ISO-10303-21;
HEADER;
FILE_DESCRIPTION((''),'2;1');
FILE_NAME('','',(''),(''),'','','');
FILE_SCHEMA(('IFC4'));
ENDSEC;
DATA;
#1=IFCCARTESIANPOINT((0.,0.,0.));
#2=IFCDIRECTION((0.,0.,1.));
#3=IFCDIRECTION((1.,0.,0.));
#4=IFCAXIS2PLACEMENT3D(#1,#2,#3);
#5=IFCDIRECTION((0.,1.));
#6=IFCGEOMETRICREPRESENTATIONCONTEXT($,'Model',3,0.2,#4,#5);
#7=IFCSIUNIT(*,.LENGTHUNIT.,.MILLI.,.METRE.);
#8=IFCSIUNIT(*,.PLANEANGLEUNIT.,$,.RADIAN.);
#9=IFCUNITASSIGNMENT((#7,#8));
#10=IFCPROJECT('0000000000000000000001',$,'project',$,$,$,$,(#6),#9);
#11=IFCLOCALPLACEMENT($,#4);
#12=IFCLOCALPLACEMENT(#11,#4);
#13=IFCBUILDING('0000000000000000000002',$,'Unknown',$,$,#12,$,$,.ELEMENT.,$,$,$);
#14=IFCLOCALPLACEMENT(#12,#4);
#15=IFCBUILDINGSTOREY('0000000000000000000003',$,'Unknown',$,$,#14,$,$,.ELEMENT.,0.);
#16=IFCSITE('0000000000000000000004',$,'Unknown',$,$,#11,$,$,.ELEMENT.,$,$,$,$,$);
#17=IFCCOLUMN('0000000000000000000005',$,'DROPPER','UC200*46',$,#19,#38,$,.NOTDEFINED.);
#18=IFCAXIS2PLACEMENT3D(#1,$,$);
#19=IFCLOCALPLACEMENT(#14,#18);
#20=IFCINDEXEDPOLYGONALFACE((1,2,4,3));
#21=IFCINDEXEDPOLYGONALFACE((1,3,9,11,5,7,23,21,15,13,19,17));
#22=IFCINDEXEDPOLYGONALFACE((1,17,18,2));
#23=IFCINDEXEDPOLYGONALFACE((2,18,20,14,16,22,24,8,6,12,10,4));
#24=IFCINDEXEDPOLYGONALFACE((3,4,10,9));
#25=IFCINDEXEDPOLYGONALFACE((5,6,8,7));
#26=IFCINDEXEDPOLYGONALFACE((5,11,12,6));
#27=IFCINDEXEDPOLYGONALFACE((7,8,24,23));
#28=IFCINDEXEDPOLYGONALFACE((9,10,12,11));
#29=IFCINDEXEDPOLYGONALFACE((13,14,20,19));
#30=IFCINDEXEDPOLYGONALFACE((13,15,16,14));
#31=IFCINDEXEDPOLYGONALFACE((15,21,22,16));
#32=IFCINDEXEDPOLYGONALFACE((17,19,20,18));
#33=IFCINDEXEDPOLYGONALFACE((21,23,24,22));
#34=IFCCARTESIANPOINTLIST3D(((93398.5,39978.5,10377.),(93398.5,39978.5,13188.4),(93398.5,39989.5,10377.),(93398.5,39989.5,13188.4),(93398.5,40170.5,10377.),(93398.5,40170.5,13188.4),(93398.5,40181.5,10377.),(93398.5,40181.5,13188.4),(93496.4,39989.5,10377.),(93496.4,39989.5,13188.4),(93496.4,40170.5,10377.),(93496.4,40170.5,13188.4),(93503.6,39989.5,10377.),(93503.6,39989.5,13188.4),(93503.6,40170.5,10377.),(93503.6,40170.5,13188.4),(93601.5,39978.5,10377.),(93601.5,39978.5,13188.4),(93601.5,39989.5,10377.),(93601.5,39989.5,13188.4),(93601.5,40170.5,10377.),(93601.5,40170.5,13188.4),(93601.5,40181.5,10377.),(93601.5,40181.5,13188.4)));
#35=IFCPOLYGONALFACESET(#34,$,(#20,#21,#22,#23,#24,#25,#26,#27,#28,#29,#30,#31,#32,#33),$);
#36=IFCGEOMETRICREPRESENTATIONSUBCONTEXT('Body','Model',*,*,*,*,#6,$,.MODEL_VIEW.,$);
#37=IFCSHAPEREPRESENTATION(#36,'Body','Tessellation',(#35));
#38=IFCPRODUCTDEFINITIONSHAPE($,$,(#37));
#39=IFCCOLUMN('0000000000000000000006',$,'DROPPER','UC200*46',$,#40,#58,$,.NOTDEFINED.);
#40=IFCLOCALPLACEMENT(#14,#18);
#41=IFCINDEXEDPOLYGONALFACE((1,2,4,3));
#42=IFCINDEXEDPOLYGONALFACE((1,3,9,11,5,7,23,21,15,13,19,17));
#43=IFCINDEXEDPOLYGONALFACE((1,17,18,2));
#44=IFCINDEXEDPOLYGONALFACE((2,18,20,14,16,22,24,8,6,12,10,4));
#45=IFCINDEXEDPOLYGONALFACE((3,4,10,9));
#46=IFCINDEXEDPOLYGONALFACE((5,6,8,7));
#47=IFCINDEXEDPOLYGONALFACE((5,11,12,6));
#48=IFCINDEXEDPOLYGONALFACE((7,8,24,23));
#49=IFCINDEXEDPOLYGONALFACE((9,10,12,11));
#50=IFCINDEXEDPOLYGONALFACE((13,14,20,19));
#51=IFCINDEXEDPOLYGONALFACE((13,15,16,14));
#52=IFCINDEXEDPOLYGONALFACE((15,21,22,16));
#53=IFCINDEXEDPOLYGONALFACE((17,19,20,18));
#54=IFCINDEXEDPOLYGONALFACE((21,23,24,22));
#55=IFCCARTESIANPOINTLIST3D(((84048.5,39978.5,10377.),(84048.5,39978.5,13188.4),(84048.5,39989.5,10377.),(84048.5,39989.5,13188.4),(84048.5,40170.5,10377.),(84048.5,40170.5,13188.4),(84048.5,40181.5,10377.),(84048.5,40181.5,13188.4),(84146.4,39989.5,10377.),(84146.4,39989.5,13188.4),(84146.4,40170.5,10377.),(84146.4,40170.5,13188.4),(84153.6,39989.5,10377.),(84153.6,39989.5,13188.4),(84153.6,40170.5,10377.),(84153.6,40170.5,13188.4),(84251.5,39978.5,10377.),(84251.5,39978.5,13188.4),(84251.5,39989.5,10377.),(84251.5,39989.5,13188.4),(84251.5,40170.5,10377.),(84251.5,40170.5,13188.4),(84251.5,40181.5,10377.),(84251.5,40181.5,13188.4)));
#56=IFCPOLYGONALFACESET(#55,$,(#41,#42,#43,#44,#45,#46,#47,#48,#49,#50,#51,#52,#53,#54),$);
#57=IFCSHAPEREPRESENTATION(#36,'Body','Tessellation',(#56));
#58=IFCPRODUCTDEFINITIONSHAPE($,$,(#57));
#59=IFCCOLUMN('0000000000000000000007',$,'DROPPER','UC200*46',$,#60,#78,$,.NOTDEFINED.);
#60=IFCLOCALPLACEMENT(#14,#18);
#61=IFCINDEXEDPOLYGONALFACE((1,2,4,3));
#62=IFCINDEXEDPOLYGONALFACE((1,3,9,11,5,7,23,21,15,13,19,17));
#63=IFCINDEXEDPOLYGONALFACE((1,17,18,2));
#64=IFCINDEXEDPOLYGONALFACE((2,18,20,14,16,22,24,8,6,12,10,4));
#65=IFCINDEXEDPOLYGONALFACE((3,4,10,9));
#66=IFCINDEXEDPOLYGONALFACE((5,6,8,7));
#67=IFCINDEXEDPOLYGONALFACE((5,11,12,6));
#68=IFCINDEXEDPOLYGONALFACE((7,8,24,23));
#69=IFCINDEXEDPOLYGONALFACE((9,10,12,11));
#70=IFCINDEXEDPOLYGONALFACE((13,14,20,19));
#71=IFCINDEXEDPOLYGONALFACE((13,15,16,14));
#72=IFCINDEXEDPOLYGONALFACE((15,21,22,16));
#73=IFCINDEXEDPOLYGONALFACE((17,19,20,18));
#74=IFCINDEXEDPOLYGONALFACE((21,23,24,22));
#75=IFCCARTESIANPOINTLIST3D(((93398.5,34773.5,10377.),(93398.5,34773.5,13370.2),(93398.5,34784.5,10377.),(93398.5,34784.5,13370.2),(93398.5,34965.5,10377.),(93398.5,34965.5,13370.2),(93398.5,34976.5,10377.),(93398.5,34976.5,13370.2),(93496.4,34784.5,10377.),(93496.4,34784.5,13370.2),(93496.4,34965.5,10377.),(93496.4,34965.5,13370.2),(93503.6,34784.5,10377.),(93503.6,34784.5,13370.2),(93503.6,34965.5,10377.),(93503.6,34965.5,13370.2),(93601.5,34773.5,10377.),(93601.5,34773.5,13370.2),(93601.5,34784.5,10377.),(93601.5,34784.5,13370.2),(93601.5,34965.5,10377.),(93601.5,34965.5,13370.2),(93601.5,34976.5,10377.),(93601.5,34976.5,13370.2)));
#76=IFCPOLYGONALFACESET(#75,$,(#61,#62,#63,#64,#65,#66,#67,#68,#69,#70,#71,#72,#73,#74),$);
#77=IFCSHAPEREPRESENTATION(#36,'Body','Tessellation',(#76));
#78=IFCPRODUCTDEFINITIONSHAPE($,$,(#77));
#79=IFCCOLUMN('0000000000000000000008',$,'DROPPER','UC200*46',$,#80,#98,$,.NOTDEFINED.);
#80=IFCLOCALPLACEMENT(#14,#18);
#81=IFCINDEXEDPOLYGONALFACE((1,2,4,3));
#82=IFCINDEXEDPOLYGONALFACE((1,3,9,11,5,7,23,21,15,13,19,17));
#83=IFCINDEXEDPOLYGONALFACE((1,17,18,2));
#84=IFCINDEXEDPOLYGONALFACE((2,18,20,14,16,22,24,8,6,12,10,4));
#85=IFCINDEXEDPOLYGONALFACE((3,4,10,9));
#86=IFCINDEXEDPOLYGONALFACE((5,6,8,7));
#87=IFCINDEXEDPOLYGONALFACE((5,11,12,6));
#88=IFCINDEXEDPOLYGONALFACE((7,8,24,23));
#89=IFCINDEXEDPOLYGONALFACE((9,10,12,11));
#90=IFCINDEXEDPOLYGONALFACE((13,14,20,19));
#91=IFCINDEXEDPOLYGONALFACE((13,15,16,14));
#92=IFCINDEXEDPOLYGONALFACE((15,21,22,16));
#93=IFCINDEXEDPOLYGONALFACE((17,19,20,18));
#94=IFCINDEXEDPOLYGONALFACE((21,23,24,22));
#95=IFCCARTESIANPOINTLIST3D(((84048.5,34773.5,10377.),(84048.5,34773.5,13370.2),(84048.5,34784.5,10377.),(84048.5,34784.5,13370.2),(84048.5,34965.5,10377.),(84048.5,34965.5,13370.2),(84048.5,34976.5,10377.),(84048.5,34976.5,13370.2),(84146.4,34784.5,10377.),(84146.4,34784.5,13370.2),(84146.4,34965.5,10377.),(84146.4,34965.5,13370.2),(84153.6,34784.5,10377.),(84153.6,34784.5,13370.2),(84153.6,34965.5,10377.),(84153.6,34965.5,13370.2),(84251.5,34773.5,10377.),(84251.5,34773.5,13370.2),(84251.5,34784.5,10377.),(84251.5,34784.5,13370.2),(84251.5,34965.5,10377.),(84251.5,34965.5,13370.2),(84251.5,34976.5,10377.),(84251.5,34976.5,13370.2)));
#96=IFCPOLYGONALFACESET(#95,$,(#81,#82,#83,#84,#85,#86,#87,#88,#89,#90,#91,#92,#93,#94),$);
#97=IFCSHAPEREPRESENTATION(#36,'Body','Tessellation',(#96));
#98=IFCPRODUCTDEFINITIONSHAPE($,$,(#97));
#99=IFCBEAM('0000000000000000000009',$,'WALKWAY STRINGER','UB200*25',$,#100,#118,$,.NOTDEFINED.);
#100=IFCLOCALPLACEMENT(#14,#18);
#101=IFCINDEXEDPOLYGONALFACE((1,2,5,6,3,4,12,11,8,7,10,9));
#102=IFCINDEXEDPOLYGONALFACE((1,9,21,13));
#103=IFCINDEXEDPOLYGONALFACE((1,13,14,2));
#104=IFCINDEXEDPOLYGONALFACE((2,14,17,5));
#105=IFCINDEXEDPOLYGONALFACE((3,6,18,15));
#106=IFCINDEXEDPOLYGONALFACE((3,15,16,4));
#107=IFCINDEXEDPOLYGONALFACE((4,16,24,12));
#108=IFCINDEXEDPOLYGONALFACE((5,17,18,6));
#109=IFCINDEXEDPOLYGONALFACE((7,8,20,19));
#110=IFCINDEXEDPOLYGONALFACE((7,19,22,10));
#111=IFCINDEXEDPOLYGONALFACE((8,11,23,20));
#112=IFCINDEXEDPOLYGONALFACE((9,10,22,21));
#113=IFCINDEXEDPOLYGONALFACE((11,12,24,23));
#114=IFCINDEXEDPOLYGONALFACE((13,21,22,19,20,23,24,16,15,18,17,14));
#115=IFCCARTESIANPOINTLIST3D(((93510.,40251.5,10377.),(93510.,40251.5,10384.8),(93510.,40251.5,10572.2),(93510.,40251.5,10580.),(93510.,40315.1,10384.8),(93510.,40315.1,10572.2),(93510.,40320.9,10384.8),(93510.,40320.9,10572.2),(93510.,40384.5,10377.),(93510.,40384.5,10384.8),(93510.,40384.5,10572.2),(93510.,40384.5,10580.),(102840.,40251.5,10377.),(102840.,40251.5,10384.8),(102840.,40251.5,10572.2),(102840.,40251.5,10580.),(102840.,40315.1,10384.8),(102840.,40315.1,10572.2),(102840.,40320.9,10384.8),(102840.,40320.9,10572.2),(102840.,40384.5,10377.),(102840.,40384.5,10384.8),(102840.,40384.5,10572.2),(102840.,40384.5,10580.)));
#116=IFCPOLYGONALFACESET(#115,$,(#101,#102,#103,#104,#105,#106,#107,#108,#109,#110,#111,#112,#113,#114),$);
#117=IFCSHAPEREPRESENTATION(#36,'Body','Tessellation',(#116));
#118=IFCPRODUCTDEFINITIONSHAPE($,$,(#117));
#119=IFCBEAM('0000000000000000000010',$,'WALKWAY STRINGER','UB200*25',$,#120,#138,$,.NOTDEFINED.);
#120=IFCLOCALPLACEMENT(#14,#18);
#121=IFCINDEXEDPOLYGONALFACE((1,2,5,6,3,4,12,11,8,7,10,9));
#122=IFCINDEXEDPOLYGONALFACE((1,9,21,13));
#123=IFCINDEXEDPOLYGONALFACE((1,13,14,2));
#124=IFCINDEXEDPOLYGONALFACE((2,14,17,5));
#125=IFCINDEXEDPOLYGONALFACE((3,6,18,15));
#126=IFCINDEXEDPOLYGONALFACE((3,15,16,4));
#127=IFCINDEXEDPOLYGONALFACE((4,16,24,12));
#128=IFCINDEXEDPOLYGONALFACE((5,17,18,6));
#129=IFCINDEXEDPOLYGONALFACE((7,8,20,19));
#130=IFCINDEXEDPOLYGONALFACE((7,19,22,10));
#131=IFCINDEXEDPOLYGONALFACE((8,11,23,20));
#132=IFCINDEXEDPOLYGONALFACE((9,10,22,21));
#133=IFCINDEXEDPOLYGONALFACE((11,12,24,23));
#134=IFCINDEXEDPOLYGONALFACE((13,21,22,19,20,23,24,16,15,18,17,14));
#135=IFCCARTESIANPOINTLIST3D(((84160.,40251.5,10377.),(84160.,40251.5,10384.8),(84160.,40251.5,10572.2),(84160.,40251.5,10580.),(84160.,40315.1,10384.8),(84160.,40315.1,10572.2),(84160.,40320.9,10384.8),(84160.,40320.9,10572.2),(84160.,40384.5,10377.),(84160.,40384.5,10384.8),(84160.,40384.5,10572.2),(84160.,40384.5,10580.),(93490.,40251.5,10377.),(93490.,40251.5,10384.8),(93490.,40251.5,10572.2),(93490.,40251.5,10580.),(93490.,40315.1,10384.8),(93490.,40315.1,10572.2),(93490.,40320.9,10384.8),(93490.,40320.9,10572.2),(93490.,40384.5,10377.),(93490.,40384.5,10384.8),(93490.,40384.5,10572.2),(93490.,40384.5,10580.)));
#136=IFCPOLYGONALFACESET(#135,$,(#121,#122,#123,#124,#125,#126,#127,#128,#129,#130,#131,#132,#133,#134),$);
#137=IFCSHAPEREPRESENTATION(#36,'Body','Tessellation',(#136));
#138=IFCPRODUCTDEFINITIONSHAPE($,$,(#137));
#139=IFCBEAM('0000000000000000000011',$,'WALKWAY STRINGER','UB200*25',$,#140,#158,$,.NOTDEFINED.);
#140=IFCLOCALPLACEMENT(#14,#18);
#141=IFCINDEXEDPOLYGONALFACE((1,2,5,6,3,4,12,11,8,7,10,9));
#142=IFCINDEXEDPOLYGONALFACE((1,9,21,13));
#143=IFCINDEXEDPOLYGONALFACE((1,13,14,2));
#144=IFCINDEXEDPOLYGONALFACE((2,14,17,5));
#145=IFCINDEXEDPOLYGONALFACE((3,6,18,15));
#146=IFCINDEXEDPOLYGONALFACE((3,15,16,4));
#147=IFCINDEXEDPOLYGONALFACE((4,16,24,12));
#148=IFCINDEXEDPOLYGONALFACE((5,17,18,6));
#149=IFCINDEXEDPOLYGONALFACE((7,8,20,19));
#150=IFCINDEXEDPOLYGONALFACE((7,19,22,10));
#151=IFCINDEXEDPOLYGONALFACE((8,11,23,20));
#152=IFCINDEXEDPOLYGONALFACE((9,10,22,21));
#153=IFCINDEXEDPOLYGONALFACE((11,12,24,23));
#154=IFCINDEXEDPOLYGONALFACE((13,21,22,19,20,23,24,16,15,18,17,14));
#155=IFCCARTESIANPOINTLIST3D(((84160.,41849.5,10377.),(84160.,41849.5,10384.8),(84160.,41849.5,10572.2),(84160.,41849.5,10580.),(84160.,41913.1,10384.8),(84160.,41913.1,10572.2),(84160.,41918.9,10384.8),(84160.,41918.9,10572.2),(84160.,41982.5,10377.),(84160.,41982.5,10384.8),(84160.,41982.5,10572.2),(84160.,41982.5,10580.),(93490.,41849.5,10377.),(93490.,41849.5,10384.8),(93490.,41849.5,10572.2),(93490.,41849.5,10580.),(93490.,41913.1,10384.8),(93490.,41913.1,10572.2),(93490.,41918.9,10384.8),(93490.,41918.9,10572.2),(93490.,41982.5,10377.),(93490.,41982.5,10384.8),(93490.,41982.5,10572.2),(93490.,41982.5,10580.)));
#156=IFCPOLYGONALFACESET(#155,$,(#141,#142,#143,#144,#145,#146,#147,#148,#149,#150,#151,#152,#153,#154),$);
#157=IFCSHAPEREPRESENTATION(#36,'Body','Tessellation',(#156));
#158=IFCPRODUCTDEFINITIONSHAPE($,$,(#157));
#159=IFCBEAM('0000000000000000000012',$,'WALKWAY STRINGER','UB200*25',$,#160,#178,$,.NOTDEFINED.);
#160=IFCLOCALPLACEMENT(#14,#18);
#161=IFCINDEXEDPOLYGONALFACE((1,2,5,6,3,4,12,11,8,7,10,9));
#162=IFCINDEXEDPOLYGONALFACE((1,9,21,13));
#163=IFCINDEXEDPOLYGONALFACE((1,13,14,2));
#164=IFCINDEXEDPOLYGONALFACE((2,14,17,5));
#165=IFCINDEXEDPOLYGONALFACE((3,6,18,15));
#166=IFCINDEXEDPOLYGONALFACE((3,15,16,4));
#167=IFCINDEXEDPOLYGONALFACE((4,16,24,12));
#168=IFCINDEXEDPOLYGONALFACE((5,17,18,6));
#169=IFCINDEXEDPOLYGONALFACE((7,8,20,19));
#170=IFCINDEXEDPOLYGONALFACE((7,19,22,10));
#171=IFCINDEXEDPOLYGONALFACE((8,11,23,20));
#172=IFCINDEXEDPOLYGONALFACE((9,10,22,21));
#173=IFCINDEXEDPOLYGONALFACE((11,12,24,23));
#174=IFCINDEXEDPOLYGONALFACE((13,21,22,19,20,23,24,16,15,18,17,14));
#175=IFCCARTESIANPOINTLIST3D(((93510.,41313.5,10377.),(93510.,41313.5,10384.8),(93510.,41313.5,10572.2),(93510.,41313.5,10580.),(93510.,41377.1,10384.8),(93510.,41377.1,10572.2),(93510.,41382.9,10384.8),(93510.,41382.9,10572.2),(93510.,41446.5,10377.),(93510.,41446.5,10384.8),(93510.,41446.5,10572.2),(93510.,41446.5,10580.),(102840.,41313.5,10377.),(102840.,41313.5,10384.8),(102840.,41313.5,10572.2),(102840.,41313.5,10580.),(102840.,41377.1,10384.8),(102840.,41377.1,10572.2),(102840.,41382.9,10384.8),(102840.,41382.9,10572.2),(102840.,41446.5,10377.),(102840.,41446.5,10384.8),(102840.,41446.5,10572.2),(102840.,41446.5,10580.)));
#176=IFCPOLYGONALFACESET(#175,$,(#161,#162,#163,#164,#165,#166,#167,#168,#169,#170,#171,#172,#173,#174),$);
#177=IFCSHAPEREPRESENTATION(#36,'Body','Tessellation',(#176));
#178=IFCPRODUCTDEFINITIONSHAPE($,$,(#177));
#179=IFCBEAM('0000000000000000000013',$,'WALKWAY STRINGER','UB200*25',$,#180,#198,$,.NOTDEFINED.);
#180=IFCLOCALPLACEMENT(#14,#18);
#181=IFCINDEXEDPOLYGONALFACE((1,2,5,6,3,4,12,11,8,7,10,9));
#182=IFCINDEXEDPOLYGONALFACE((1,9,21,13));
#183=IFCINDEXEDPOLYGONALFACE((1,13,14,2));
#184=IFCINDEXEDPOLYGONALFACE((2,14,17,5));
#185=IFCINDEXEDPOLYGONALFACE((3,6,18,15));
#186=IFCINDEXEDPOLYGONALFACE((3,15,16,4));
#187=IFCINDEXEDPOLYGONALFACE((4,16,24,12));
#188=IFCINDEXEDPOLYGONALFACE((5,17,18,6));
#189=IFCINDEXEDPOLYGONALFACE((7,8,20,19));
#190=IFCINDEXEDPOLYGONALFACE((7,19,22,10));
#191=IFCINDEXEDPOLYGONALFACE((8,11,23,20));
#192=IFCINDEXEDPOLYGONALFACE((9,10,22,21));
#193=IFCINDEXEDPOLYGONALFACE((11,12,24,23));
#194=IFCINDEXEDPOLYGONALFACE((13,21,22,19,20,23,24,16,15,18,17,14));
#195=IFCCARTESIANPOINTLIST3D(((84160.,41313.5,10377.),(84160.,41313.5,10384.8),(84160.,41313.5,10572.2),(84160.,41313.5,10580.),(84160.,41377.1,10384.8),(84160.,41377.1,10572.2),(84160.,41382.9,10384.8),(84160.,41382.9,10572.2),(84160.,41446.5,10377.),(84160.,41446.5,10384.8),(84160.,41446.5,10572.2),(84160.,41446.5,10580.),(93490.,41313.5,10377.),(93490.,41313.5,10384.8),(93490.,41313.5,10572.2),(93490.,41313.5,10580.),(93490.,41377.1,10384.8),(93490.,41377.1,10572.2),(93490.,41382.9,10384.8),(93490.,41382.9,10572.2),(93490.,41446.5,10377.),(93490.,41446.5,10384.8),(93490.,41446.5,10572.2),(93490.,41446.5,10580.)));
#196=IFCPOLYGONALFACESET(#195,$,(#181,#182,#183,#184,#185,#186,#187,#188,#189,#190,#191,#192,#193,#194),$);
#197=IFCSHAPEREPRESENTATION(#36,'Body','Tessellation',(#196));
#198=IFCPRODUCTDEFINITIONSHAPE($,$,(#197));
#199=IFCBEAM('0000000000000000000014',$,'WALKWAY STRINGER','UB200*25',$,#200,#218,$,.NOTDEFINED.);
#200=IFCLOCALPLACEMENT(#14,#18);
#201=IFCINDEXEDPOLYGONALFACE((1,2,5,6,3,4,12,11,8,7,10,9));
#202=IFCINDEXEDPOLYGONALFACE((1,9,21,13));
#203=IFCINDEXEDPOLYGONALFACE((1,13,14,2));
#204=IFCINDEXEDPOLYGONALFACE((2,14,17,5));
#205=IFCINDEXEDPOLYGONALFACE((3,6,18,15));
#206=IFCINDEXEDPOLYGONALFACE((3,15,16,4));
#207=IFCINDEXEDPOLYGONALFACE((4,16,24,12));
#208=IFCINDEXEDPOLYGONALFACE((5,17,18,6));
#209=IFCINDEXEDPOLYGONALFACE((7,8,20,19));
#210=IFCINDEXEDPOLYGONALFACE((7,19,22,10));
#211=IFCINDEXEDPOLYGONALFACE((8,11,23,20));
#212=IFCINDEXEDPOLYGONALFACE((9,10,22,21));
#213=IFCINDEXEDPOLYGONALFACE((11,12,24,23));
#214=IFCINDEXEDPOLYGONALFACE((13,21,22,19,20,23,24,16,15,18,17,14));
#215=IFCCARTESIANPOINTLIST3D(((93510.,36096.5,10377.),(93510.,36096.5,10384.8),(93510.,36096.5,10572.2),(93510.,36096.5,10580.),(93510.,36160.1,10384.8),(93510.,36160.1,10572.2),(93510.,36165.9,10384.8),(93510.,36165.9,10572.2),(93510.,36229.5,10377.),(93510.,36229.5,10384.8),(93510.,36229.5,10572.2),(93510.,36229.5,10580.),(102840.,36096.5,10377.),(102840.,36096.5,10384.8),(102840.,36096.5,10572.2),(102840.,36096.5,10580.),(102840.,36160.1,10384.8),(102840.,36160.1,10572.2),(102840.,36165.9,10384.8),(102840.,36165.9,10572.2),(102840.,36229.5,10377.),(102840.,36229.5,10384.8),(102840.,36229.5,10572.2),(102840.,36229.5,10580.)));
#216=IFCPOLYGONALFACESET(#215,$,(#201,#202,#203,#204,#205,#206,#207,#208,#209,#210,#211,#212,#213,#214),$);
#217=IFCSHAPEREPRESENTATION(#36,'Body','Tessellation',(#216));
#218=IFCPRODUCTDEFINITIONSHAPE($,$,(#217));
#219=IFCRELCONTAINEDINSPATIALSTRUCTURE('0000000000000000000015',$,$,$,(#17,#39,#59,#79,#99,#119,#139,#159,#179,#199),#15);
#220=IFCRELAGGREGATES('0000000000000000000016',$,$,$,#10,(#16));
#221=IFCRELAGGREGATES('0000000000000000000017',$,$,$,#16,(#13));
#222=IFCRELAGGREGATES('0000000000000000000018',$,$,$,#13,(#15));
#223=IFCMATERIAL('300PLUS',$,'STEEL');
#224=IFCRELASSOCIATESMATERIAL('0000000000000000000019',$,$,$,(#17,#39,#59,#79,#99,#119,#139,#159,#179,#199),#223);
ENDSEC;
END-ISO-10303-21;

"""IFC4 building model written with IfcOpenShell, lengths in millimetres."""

from ifc_helpers import new_model, si_unit, direction, frame, origin_with_axes, place, context, subcontext, project, spatial, line, indexed_curve, outline, extrude, material, element, save


model = new_model("IFC4")

# Units and contexts
model_context = context("Model", 3, precision=0.2, world=origin_with_axes(), true_north=direction((0.0, 1.0)))
body_context = subcontext(model_context, "Body", "Model", "MODEL_VIEW")
ifc_project = project(units=[si_unit("LENGTHUNIT", "METRE", prefix="MILLI"), si_unit("PLANEANGLEUNIT", "RADIAN")], contexts=[model_context])

# Site, building, storey
site_placement = place(None, origin_with_axes())
site = spatial("IfcSite", under=ifc_project, at=site_placement, Name="Unknown", CompositionType="ELEMENT")
building_placement = place(site_placement, origin_with_axes())
building = spatial("IfcBuilding", under=site, at=building_placement, Name="Unknown", CompositionType="ELEMENT")
storey_placement = place(building_placement, origin_with_axes())
storey = spatial("IfcBuildingStorey", under=building, at=storey_placement, Name="Unknown", CompositionType="ELEMENT", Elevation=0.0)

# Columns
ifc_material_1 = material(Name="300PLUS", Category="STEEL")
for number, where, z_axis, x_axis, name in (
    (1, (93500.0, 40080.0, 10377.0), (-1.0, 0.0, 0.0), (0.0, 0.0, 1.0), "DROPPER"),
    (2, (84150.0, 40080.0, 10377.0), (-1.0, 0.0, 0.0), (0.0, 0.0, 1.0), "DROPPER"),
):
    element("IfcColumn", number, at=place(storey_placement, frame(where, z_axis=z_axis, x_axis=x_axis)), inside=storey, material=ifc_material_1, Name=name, Description="UC200*46", PredefinedType="NOTDEFINED", context=body_context, shape_type="SolidModel", body=[
        extrude(outline(indexed_curve([(-101.5, -101.5), (101.5, -101.5), (101.5, -90.5), (3.6, -90.5), (3.6, 90.5), (101.5, 90.5), (101.5, 101.5), (-101.5, 101.5), (-101.5, 90.5), (-3.6, 90.5), (-3.6, -90.5), (-101.5, -90.5)], segments=[line(1, 2, 3, 4, 5, 6, 7, 8, 9, 10, 11, 12, 1)])), frame((0.0, 0.0, 0.0), z_axis=(-1.0, 0.0, 0.0), x_axis=(0.0, 0.0, 1.0)), (0.0, 0.0, -1.0), 2811.4),
    ])
for number, where, z_axis, x_axis, name in (
    (3, (93500.0, 34875.0, 10377.0), (-1.0, 0.0, 0.0), (0.0, 0.0, 1.0), "DROPPER"),
    (4, (84150.0, 34875.0, 10377.0), (-1.0, 0.0, 0.0), (0.0, 0.0, 1.0), "DROPPER"),
):
    element("IfcColumn", number, at=place(storey_placement, frame(where, z_axis=z_axis, x_axis=x_axis)), inside=storey, material=ifc_material_1, Name=name, Description="UC200*46", PredefinedType="NOTDEFINED", context=body_context, shape_type="SolidModel", body=[
        extrude(outline(indexed_curve([(-101.5, -101.5), (101.5, -101.5), (101.5, -90.5), (3.6, -90.5), (3.6, 90.5), (101.5, 90.5), (101.5, 101.5), (-101.5, 101.5), (-101.5, 90.5), (-3.6, 90.5), (-3.6, -90.5), (-101.5, -90.5)], segments=[line(1, 2, 3, 4, 5, 6, 7, 8, 9, 10, 11, 12, 1)])), frame((0.0, 0.0, 0.0), z_axis=(-1.0, 0.0, 0.0), x_axis=(0.0, 0.0, 1.0)), (0.0, 0.0, -1.0), 2993.2),
    ])

# Beams
for number, where, z_axis, x_axis, name in (
    (5, (93510.0, 40318.0, 10478.5), (0.0, -1.0, 0.0), (1.0, 0.0, 0.0), "WALKWAY STRINGER"),
    (6, (84160.0, 40318.0, 10478.5), (0.0, -1.0, 0.0), (1.0, 0.0, 0.0), "WALKWAY STRINGER"),
    (7, (84160.0, 41916.0, 10478.5), (0.0, -1.0, 0.0), (1.0, 0.0, 0.0), "WALKWAY STRINGER"),
    (8, (93510.0, 41380.0, 10478.5), (0.0, -1.0, 0.0), (1.0, 0.0, 0.0), "WALKWAY STRINGER"),
    (9, (84160.0, 41380.0, 10478.5), (0.0, -1.0, 0.0), (1.0, 0.0, 0.0), "WALKWAY STRINGER"),
    (10, (93510.0, 36163.0, 10478.5), (0.0, -1.0, 0.0), (1.0, 0.0, 0.0), "WALKWAY STRINGER"),
):
    element("IfcBeam", number, at=place(storey_placement, frame(where, z_axis=z_axis, x_axis=x_axis)), inside=storey, material=ifc_material_1, Name=name, Description="UB200*25", PredefinedType="NOTDEFINED", context=body_context, shape_type="SolidModel", body=[
        extrude(outline(indexed_curve([(-66.5, -101.5), (66.5, -101.5), (66.5, -93.7), (2.9, -93.7), (2.9, 93.7), (66.5, 93.7), (66.5, 101.5), (-66.5, 101.5), (-66.5, 93.7), (-2.9, 93.7), (-2.9, -93.7), (-66.5, -93.7)], segments=[line(1, 2, 3, 4, 5, 6, 7, 8, 9, 10, 11, 12, 1)])), frame((0.0, 0.0, 0.0), z_axis=(-1.0, 0.0, 0.0), x_axis=(0.0, 0.0, 1.0)), (0.0, 0.0, -1.0), 9330.0),
    ])

save(model, "model.ifc")
